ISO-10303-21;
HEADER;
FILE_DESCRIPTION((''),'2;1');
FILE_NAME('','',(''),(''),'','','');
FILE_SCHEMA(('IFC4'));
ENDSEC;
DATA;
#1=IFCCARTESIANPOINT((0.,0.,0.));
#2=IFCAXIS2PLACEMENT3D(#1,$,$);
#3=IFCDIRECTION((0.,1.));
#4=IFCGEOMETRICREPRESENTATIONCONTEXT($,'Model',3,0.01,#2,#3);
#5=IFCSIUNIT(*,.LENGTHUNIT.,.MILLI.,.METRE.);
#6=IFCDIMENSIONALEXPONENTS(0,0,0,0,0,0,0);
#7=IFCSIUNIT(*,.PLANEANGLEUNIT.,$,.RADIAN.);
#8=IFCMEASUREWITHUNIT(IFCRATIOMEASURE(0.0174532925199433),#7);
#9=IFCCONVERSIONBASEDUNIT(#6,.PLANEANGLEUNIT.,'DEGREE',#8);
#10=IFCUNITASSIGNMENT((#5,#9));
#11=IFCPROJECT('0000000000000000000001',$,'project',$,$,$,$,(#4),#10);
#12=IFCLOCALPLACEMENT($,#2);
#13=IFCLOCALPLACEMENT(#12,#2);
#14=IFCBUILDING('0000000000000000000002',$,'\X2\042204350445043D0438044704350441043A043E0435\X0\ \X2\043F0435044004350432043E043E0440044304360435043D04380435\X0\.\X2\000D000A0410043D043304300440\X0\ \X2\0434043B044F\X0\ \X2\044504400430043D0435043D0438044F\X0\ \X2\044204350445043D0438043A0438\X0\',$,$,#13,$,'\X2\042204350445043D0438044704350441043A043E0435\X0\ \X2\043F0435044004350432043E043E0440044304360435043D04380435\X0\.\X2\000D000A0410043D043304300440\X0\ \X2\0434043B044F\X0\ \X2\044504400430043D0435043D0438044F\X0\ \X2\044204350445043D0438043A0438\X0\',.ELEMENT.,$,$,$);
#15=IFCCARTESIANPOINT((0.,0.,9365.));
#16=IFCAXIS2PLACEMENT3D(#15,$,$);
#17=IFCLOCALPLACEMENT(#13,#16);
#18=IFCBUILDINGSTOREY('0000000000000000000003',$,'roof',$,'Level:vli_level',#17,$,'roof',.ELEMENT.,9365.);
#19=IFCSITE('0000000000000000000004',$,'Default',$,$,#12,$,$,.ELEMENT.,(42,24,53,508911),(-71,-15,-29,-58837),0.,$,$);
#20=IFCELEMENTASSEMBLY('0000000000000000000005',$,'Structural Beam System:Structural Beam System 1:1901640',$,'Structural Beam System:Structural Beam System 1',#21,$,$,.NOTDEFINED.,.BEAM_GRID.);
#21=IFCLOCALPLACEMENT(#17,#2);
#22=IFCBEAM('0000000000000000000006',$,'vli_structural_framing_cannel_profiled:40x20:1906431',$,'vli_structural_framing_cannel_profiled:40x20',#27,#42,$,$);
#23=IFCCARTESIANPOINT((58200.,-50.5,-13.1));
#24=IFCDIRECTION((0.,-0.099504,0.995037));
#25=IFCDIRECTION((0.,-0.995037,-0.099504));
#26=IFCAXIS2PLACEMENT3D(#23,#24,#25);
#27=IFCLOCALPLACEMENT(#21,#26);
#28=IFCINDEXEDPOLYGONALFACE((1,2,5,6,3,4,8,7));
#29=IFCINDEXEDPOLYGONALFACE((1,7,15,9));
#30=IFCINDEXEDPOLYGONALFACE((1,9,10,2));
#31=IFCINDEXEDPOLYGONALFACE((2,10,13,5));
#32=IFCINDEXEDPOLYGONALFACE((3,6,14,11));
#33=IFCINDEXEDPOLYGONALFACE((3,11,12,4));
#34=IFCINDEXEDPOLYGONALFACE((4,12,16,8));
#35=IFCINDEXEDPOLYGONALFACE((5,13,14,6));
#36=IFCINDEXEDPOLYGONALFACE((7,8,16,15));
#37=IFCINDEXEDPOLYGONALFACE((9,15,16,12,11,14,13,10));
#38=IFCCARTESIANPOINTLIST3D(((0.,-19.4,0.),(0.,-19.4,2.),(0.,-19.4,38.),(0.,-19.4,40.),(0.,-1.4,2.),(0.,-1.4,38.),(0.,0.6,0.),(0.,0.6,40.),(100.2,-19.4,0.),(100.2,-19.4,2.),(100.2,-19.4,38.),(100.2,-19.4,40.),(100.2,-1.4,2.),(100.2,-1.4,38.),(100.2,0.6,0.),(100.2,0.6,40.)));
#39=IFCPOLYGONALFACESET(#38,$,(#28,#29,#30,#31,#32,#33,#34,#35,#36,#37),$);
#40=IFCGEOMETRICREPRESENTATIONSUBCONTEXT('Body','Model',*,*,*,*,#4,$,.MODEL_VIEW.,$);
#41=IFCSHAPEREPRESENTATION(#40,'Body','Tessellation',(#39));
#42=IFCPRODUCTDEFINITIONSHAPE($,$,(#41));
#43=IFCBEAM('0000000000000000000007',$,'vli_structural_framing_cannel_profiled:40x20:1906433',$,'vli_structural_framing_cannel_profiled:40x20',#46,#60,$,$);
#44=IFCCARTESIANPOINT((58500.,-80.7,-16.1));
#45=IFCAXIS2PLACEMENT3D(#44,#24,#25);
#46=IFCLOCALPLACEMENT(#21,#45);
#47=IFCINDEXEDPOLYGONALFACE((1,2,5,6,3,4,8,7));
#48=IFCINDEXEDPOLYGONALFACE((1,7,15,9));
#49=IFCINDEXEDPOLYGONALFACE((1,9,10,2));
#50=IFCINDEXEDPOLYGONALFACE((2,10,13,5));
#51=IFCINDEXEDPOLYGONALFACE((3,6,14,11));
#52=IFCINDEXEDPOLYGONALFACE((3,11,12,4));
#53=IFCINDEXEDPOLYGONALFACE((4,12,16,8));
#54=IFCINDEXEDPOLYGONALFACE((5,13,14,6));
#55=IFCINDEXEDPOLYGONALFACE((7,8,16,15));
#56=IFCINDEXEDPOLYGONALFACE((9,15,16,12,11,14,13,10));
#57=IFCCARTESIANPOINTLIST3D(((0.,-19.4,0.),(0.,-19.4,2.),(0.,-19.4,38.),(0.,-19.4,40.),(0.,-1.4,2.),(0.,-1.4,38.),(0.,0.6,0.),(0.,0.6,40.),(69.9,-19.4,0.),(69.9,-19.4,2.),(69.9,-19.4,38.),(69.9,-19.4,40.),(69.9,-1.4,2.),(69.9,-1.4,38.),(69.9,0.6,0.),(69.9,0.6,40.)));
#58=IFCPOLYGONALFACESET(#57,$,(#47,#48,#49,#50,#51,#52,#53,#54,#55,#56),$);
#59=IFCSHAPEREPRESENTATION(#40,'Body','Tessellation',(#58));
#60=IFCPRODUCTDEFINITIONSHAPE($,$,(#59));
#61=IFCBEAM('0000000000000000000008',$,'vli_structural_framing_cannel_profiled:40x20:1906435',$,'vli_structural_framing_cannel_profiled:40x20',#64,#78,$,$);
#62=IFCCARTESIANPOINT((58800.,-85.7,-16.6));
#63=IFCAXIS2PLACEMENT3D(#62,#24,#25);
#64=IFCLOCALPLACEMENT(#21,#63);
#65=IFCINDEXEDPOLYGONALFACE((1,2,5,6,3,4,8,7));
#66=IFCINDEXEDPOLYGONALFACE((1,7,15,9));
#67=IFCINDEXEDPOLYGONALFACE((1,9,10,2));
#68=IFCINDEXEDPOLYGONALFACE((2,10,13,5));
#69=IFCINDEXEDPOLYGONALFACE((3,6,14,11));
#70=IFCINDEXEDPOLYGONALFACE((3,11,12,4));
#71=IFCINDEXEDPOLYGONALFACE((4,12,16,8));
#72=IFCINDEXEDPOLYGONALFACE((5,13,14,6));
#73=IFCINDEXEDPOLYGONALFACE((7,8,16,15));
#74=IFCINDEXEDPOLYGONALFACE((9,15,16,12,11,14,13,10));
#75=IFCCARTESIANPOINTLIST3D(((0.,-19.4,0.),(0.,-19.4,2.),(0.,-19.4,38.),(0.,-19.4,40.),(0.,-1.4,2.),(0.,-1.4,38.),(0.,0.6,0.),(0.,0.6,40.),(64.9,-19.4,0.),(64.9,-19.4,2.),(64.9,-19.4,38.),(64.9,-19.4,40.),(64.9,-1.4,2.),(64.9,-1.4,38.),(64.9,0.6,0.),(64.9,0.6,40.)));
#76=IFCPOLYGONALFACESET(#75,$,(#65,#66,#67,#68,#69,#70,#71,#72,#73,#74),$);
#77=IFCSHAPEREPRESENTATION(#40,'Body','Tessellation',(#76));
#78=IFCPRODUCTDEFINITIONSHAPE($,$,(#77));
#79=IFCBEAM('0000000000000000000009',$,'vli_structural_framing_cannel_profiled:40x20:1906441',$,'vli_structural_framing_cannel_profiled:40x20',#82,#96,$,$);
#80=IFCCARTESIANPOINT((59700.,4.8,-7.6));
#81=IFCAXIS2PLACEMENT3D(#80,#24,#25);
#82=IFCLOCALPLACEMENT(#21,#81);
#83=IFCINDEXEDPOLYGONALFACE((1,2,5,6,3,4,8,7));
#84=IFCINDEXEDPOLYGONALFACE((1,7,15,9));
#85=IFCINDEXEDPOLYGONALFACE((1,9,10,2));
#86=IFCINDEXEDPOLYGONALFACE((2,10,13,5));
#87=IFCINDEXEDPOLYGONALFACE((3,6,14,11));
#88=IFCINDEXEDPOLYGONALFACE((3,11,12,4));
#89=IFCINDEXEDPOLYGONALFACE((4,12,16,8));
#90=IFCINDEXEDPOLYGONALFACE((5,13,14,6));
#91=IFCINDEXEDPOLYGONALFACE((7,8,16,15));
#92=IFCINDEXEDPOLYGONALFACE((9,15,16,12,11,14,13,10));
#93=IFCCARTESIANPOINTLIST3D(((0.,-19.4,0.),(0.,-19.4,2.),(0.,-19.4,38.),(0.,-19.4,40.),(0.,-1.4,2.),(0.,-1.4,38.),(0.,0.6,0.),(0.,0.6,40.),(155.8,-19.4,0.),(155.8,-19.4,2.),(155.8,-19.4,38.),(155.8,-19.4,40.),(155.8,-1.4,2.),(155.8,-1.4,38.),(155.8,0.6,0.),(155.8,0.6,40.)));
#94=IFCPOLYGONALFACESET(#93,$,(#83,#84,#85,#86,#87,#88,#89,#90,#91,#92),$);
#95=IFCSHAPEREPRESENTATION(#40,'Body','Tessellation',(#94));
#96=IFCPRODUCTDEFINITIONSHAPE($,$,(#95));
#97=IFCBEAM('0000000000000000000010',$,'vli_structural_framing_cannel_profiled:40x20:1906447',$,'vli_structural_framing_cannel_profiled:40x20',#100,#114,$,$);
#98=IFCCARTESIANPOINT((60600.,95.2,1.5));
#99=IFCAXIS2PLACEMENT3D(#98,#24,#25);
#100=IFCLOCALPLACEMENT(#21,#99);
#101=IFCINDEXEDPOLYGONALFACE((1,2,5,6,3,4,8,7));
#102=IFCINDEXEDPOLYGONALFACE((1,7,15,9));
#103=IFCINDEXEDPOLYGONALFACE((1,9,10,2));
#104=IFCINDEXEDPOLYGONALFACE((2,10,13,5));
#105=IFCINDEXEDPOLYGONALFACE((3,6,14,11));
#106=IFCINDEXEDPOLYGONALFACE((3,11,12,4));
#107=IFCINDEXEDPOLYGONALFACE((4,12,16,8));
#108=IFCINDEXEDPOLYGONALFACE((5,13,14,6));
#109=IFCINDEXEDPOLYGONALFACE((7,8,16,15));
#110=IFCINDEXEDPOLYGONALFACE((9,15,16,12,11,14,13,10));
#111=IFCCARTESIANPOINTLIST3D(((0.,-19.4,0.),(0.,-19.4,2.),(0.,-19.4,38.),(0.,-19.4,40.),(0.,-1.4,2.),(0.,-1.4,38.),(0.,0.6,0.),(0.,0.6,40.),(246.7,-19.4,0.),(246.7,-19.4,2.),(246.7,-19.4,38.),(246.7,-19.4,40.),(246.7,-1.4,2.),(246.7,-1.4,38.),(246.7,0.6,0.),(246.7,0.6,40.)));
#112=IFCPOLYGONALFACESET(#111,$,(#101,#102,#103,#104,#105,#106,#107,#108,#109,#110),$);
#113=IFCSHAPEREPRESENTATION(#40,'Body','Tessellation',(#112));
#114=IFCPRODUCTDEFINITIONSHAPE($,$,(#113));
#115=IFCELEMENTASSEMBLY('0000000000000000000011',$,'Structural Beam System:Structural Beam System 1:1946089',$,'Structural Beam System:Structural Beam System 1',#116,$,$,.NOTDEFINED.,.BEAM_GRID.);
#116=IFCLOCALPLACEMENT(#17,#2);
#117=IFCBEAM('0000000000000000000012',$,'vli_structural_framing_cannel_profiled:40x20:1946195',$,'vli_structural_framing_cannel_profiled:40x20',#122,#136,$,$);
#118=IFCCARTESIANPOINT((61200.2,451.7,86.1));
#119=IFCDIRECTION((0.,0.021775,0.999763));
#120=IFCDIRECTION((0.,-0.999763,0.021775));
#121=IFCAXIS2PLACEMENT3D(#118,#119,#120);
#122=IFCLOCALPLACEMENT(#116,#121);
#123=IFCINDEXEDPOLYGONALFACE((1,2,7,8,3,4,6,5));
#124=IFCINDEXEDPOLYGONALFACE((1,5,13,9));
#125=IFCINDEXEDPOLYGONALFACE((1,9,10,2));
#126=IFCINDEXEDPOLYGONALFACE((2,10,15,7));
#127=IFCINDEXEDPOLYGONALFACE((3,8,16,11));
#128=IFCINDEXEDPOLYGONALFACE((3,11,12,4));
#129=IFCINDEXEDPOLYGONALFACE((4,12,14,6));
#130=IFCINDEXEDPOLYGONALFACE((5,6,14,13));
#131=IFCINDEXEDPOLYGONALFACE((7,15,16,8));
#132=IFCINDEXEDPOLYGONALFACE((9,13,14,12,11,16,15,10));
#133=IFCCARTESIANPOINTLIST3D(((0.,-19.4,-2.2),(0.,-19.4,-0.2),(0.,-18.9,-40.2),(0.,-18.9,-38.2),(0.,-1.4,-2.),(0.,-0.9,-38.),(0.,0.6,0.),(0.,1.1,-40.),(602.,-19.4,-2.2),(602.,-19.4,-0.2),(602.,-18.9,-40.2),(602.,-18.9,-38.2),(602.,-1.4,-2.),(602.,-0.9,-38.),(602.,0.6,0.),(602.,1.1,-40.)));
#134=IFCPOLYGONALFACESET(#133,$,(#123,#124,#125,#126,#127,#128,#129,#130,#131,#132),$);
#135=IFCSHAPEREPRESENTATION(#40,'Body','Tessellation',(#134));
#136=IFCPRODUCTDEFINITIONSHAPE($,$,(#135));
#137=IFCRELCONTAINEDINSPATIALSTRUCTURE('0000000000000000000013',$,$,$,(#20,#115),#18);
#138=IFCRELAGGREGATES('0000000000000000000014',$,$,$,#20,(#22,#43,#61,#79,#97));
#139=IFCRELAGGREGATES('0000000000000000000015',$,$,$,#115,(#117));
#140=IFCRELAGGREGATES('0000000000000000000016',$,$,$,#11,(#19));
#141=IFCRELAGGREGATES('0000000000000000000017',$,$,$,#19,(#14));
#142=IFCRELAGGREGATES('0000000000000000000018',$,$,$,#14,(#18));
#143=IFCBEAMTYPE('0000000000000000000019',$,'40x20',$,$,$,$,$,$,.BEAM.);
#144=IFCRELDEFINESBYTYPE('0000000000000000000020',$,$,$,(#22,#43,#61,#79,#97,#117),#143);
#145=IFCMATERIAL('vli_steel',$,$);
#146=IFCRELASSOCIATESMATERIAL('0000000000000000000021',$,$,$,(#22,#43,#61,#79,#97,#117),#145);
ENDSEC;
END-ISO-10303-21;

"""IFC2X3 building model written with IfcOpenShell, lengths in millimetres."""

from ifc_helpers import new_model, entity, si_unit, converted_unit, direction, frame, origin, place, context, subcontext, project, spatial, polyline, outline, extrude, material, type_object, element, aggregate, save


model = new_model("IFC2X3")

# Units and contexts
model_context = context("Model", 3, precision=0.01, world=origin(), true_north=direction((0.0, 1.0)))
body_context = subcontext(model_context, "Body", "Model", "MODEL_VIEW")
ifc_project = project(units=[si_unit("LENGTHUNIT", "METRE", prefix="MILLI"), converted_unit("PLANEANGLEUNIT", "DEGREE", entity("IfcRatioMeasure", 0.0174532925199433), si_unit("PLANEANGLEUNIT", "RADIAN"), dimensions=[0, 0, 0, 0, 0, 0, 0])], contexts=[model_context])

# Site, building, storey
site_placement = place(None, origin())
site = spatial("IfcSite", under=ifc_project, at=site_placement, Name="Default", CompositionType="ELEMENT", RefLatitude=(42, 24, 53, 508911), RefLongitude=(-71, -15, -29, -58837), RefElevation=0.0)
building_placement = place(site_placement, origin())
building = spatial("IfcBuilding", under=site, at=building_placement, Name="Техническое перевооружение.\r\nАнгар для хранения техники", LongName="Техническое перевооружение.\r\nАнгар для хранения техники", CompositionType="ELEMENT")
storey_placement = place(building_placement, frame((0.0, 0.0, 9365.0)))
storey = spatial("IfcBuildingStorey", under=building, at=storey_placement, Name="roof", ObjectType="Level:vli_level", LongName="roof", CompositionType="ELEMENT", Elevation=9365.0)

# Element assembly, beams
assembly_1_placement = place(storey_placement, origin())
assembly_1 = element("IfcElementAssembly", 1, at=assembly_1_placement, inside=storey, Name="Structural Beam System:Structural Beam System 1:1901640", ObjectType="Structural Beam System:Structural Beam System 1", AssemblyPlace="NOTDEFINED", PredefinedType="BEAM_GRID")
ifc_material = material(Name="vli_steel")
beam_type = type_object("IfcBeamType", Name="40x20", PredefinedType="BEAM")
beam_1_placement = place(assembly_1_placement, frame((58200.0, -50.5, -13.1), z_axis=(0.0, -0.099504, 0.995037), x_axis=(0.0, -0.995037, -0.099504)))
beam_1 = element("IfcBeam", 2, at=beam_1_placement, type_object=beam_type, material=ifc_material, Name="vli_structural_framing_cannel_profiled:40x20:1906431", ObjectType="vli_structural_framing_cannel_profiled:40x20", context=body_context, shape_type="SweptSolid", body=[
    extrude(outline(polyline([(-20.0, -9.5), (-18.0, -9.5), (-18.0, 8.5), (18.0, 8.5), (18.0, -9.5), (20.0, -9.5), (20.0, 10.5), (-20.0, 10.5), (-20.0, -9.5)])), frame((0.0, -9.9, 20.0), z_axis=(1.0, 0.0, 0.0), x_axis=(0.0, 0.0, -1.0)), (0.0, 0.0, 1.0), 100.2),
])
beam_2_placement = place(assembly_1_placement, frame((58500.0, -80.7, -16.1), z_axis=(0.0, -0.099504, 0.995037), x_axis=(0.0, -0.995037, -0.099504)))
beam_2 = element("IfcBeam", 3, at=beam_2_placement, type_object=beam_type, material=ifc_material, Name="vli_structural_framing_cannel_profiled:40x20:1906433", ObjectType="vli_structural_framing_cannel_profiled:40x20", context=body_context, shape_type="SweptSolid", body=[
    extrude(outline(polyline([(-20.0, -9.5), (-18.0, -9.5), (-18.0, 8.5), (18.0, 8.5), (18.0, -9.5), (20.0, -9.5), (20.0, 10.5), (-20.0, 10.5), (-20.0, -9.5)])), frame((0.0, -9.9, 20.0), z_axis=(1.0, 0.0, 0.0), x_axis=(0.0, 0.0, -1.0)), (0.0, 0.0, 1.0), 69.9),
])
beam_3_placement = place(assembly_1_placement, frame((58800.0, -85.7, -16.6), z_axis=(0.0, -0.099504, 0.995037), x_axis=(0.0, -0.995037, -0.099504)))
beam_3 = element("IfcBeam", 4, at=beam_3_placement, type_object=beam_type, material=ifc_material, Name="vli_structural_framing_cannel_profiled:40x20:1906435", ObjectType="vli_structural_framing_cannel_profiled:40x20", context=body_context, shape_type="SweptSolid", body=[
    extrude(outline(polyline([(-20.0, -9.5), (-18.0, -9.5), (-18.0, 8.5), (18.0, 8.5), (18.0, -9.5), (20.0, -9.5), (20.0, 10.5), (-20.0, 10.5), (-20.0, -9.5)])), frame((0.0, -9.9, 20.0), z_axis=(1.0, 0.0, 0.0), x_axis=(0.0, 0.0, -1.0)), (0.0, 0.0, 1.0), 64.9),
])
beam_4_placement = place(assembly_1_placement, frame((59700.0, 4.8, -7.6), z_axis=(0.0, -0.099504, 0.995037), x_axis=(0.0, -0.995037, -0.099504)))
beam_4 = element("IfcBeam", 5, at=beam_4_placement, type_object=beam_type, material=ifc_material, Name="vli_structural_framing_cannel_profiled:40x20:1906441", ObjectType="vli_structural_framing_cannel_profiled:40x20", context=body_context, shape_type="SweptSolid", body=[
    extrude(outline(polyline([(-20.0, -9.5), (-18.0, -9.5), (-18.0, 8.5), (18.0, 8.5), (18.0, -9.5), (20.0, -9.5), (20.0, 10.5), (-20.0, 10.5), (-20.0, -9.5)])), frame((0.0, -9.9, 20.0), z_axis=(1.0, 0.0, 0.0), x_axis=(0.0, 0.0, -1.0)), (0.0, 0.0, 1.0), 155.8),
])
beam_5_placement = place(assembly_1_placement, frame((60600.0, 95.2, 1.5), z_axis=(0.0, -0.099504, 0.995037), x_axis=(0.0, -0.995037, -0.099504)))
beam_5 = element("IfcBeam", 6, at=beam_5_placement, type_object=beam_type, material=ifc_material, Name="vli_structural_framing_cannel_profiled:40x20:1906447", ObjectType="vli_structural_framing_cannel_profiled:40x20", context=body_context, shape_type="SweptSolid", body=[
    extrude(outline(polyline([(-20.0, -9.5), (-18.0, -9.5), (-18.0, 8.5), (18.0, 8.5), (18.0, -9.5), (20.0, -9.5), (20.0, 10.5), (-20.0, 10.5), (-20.0, -9.5)])), frame((0.0, -9.9, 20.0), z_axis=(1.0, 0.0, 0.0), x_axis=(0.0, 0.0, -1.0)), (0.0, 0.0, 1.0), 246.7),
])
aggregate(assembly_1, [beam_1, beam_2, beam_3, beam_4, beam_5])

# Element assembly, beam
assembly_2_placement = place(storey_placement, origin())
assembly_2 = element("IfcElementAssembly", 7, at=assembly_2_placement, inside=storey, Name="Structural Beam System:Structural Beam System 1:1946089", ObjectType="Structural Beam System:Structural Beam System 1", AssemblyPlace="NOTDEFINED", PredefinedType="BEAM_GRID")
beam_6_placement = place(assembly_2_placement, frame((61200.2, 451.7, 86.1), z_axis=(0.0, 0.021775, 0.999763), x_axis=(0.0, -0.999763, 0.021775)))
beam_6 = element("IfcBeam", 8, at=beam_6_placement, type_object=beam_type, material=ifc_material, Name="vli_structural_framing_cannel_profiled:40x20:1946195", ObjectType="vli_structural_framing_cannel_profiled:40x20", context=body_context, shape_type="SweptSolid", body=[
    extrude(outline(polyline([(-10.5, -20.0), (9.5, -20.0), (9.5, -18.0), (-8.5, -18.0), (-8.5, 18.0), (9.5, 18.0), (9.5, 20.0), (-10.5, 20.0), (-10.5, -20.0)])), frame((0.0, -9.7, -20.1), z_axis=(1.0, 0.0, 0.0), x_axis=(0.0, -0.999925, -0.01227)), (0.0, 0.0, 1.0), 602.0),
])
aggregate(assembly_2, [beam_6])

save(model, "model.ifc")
